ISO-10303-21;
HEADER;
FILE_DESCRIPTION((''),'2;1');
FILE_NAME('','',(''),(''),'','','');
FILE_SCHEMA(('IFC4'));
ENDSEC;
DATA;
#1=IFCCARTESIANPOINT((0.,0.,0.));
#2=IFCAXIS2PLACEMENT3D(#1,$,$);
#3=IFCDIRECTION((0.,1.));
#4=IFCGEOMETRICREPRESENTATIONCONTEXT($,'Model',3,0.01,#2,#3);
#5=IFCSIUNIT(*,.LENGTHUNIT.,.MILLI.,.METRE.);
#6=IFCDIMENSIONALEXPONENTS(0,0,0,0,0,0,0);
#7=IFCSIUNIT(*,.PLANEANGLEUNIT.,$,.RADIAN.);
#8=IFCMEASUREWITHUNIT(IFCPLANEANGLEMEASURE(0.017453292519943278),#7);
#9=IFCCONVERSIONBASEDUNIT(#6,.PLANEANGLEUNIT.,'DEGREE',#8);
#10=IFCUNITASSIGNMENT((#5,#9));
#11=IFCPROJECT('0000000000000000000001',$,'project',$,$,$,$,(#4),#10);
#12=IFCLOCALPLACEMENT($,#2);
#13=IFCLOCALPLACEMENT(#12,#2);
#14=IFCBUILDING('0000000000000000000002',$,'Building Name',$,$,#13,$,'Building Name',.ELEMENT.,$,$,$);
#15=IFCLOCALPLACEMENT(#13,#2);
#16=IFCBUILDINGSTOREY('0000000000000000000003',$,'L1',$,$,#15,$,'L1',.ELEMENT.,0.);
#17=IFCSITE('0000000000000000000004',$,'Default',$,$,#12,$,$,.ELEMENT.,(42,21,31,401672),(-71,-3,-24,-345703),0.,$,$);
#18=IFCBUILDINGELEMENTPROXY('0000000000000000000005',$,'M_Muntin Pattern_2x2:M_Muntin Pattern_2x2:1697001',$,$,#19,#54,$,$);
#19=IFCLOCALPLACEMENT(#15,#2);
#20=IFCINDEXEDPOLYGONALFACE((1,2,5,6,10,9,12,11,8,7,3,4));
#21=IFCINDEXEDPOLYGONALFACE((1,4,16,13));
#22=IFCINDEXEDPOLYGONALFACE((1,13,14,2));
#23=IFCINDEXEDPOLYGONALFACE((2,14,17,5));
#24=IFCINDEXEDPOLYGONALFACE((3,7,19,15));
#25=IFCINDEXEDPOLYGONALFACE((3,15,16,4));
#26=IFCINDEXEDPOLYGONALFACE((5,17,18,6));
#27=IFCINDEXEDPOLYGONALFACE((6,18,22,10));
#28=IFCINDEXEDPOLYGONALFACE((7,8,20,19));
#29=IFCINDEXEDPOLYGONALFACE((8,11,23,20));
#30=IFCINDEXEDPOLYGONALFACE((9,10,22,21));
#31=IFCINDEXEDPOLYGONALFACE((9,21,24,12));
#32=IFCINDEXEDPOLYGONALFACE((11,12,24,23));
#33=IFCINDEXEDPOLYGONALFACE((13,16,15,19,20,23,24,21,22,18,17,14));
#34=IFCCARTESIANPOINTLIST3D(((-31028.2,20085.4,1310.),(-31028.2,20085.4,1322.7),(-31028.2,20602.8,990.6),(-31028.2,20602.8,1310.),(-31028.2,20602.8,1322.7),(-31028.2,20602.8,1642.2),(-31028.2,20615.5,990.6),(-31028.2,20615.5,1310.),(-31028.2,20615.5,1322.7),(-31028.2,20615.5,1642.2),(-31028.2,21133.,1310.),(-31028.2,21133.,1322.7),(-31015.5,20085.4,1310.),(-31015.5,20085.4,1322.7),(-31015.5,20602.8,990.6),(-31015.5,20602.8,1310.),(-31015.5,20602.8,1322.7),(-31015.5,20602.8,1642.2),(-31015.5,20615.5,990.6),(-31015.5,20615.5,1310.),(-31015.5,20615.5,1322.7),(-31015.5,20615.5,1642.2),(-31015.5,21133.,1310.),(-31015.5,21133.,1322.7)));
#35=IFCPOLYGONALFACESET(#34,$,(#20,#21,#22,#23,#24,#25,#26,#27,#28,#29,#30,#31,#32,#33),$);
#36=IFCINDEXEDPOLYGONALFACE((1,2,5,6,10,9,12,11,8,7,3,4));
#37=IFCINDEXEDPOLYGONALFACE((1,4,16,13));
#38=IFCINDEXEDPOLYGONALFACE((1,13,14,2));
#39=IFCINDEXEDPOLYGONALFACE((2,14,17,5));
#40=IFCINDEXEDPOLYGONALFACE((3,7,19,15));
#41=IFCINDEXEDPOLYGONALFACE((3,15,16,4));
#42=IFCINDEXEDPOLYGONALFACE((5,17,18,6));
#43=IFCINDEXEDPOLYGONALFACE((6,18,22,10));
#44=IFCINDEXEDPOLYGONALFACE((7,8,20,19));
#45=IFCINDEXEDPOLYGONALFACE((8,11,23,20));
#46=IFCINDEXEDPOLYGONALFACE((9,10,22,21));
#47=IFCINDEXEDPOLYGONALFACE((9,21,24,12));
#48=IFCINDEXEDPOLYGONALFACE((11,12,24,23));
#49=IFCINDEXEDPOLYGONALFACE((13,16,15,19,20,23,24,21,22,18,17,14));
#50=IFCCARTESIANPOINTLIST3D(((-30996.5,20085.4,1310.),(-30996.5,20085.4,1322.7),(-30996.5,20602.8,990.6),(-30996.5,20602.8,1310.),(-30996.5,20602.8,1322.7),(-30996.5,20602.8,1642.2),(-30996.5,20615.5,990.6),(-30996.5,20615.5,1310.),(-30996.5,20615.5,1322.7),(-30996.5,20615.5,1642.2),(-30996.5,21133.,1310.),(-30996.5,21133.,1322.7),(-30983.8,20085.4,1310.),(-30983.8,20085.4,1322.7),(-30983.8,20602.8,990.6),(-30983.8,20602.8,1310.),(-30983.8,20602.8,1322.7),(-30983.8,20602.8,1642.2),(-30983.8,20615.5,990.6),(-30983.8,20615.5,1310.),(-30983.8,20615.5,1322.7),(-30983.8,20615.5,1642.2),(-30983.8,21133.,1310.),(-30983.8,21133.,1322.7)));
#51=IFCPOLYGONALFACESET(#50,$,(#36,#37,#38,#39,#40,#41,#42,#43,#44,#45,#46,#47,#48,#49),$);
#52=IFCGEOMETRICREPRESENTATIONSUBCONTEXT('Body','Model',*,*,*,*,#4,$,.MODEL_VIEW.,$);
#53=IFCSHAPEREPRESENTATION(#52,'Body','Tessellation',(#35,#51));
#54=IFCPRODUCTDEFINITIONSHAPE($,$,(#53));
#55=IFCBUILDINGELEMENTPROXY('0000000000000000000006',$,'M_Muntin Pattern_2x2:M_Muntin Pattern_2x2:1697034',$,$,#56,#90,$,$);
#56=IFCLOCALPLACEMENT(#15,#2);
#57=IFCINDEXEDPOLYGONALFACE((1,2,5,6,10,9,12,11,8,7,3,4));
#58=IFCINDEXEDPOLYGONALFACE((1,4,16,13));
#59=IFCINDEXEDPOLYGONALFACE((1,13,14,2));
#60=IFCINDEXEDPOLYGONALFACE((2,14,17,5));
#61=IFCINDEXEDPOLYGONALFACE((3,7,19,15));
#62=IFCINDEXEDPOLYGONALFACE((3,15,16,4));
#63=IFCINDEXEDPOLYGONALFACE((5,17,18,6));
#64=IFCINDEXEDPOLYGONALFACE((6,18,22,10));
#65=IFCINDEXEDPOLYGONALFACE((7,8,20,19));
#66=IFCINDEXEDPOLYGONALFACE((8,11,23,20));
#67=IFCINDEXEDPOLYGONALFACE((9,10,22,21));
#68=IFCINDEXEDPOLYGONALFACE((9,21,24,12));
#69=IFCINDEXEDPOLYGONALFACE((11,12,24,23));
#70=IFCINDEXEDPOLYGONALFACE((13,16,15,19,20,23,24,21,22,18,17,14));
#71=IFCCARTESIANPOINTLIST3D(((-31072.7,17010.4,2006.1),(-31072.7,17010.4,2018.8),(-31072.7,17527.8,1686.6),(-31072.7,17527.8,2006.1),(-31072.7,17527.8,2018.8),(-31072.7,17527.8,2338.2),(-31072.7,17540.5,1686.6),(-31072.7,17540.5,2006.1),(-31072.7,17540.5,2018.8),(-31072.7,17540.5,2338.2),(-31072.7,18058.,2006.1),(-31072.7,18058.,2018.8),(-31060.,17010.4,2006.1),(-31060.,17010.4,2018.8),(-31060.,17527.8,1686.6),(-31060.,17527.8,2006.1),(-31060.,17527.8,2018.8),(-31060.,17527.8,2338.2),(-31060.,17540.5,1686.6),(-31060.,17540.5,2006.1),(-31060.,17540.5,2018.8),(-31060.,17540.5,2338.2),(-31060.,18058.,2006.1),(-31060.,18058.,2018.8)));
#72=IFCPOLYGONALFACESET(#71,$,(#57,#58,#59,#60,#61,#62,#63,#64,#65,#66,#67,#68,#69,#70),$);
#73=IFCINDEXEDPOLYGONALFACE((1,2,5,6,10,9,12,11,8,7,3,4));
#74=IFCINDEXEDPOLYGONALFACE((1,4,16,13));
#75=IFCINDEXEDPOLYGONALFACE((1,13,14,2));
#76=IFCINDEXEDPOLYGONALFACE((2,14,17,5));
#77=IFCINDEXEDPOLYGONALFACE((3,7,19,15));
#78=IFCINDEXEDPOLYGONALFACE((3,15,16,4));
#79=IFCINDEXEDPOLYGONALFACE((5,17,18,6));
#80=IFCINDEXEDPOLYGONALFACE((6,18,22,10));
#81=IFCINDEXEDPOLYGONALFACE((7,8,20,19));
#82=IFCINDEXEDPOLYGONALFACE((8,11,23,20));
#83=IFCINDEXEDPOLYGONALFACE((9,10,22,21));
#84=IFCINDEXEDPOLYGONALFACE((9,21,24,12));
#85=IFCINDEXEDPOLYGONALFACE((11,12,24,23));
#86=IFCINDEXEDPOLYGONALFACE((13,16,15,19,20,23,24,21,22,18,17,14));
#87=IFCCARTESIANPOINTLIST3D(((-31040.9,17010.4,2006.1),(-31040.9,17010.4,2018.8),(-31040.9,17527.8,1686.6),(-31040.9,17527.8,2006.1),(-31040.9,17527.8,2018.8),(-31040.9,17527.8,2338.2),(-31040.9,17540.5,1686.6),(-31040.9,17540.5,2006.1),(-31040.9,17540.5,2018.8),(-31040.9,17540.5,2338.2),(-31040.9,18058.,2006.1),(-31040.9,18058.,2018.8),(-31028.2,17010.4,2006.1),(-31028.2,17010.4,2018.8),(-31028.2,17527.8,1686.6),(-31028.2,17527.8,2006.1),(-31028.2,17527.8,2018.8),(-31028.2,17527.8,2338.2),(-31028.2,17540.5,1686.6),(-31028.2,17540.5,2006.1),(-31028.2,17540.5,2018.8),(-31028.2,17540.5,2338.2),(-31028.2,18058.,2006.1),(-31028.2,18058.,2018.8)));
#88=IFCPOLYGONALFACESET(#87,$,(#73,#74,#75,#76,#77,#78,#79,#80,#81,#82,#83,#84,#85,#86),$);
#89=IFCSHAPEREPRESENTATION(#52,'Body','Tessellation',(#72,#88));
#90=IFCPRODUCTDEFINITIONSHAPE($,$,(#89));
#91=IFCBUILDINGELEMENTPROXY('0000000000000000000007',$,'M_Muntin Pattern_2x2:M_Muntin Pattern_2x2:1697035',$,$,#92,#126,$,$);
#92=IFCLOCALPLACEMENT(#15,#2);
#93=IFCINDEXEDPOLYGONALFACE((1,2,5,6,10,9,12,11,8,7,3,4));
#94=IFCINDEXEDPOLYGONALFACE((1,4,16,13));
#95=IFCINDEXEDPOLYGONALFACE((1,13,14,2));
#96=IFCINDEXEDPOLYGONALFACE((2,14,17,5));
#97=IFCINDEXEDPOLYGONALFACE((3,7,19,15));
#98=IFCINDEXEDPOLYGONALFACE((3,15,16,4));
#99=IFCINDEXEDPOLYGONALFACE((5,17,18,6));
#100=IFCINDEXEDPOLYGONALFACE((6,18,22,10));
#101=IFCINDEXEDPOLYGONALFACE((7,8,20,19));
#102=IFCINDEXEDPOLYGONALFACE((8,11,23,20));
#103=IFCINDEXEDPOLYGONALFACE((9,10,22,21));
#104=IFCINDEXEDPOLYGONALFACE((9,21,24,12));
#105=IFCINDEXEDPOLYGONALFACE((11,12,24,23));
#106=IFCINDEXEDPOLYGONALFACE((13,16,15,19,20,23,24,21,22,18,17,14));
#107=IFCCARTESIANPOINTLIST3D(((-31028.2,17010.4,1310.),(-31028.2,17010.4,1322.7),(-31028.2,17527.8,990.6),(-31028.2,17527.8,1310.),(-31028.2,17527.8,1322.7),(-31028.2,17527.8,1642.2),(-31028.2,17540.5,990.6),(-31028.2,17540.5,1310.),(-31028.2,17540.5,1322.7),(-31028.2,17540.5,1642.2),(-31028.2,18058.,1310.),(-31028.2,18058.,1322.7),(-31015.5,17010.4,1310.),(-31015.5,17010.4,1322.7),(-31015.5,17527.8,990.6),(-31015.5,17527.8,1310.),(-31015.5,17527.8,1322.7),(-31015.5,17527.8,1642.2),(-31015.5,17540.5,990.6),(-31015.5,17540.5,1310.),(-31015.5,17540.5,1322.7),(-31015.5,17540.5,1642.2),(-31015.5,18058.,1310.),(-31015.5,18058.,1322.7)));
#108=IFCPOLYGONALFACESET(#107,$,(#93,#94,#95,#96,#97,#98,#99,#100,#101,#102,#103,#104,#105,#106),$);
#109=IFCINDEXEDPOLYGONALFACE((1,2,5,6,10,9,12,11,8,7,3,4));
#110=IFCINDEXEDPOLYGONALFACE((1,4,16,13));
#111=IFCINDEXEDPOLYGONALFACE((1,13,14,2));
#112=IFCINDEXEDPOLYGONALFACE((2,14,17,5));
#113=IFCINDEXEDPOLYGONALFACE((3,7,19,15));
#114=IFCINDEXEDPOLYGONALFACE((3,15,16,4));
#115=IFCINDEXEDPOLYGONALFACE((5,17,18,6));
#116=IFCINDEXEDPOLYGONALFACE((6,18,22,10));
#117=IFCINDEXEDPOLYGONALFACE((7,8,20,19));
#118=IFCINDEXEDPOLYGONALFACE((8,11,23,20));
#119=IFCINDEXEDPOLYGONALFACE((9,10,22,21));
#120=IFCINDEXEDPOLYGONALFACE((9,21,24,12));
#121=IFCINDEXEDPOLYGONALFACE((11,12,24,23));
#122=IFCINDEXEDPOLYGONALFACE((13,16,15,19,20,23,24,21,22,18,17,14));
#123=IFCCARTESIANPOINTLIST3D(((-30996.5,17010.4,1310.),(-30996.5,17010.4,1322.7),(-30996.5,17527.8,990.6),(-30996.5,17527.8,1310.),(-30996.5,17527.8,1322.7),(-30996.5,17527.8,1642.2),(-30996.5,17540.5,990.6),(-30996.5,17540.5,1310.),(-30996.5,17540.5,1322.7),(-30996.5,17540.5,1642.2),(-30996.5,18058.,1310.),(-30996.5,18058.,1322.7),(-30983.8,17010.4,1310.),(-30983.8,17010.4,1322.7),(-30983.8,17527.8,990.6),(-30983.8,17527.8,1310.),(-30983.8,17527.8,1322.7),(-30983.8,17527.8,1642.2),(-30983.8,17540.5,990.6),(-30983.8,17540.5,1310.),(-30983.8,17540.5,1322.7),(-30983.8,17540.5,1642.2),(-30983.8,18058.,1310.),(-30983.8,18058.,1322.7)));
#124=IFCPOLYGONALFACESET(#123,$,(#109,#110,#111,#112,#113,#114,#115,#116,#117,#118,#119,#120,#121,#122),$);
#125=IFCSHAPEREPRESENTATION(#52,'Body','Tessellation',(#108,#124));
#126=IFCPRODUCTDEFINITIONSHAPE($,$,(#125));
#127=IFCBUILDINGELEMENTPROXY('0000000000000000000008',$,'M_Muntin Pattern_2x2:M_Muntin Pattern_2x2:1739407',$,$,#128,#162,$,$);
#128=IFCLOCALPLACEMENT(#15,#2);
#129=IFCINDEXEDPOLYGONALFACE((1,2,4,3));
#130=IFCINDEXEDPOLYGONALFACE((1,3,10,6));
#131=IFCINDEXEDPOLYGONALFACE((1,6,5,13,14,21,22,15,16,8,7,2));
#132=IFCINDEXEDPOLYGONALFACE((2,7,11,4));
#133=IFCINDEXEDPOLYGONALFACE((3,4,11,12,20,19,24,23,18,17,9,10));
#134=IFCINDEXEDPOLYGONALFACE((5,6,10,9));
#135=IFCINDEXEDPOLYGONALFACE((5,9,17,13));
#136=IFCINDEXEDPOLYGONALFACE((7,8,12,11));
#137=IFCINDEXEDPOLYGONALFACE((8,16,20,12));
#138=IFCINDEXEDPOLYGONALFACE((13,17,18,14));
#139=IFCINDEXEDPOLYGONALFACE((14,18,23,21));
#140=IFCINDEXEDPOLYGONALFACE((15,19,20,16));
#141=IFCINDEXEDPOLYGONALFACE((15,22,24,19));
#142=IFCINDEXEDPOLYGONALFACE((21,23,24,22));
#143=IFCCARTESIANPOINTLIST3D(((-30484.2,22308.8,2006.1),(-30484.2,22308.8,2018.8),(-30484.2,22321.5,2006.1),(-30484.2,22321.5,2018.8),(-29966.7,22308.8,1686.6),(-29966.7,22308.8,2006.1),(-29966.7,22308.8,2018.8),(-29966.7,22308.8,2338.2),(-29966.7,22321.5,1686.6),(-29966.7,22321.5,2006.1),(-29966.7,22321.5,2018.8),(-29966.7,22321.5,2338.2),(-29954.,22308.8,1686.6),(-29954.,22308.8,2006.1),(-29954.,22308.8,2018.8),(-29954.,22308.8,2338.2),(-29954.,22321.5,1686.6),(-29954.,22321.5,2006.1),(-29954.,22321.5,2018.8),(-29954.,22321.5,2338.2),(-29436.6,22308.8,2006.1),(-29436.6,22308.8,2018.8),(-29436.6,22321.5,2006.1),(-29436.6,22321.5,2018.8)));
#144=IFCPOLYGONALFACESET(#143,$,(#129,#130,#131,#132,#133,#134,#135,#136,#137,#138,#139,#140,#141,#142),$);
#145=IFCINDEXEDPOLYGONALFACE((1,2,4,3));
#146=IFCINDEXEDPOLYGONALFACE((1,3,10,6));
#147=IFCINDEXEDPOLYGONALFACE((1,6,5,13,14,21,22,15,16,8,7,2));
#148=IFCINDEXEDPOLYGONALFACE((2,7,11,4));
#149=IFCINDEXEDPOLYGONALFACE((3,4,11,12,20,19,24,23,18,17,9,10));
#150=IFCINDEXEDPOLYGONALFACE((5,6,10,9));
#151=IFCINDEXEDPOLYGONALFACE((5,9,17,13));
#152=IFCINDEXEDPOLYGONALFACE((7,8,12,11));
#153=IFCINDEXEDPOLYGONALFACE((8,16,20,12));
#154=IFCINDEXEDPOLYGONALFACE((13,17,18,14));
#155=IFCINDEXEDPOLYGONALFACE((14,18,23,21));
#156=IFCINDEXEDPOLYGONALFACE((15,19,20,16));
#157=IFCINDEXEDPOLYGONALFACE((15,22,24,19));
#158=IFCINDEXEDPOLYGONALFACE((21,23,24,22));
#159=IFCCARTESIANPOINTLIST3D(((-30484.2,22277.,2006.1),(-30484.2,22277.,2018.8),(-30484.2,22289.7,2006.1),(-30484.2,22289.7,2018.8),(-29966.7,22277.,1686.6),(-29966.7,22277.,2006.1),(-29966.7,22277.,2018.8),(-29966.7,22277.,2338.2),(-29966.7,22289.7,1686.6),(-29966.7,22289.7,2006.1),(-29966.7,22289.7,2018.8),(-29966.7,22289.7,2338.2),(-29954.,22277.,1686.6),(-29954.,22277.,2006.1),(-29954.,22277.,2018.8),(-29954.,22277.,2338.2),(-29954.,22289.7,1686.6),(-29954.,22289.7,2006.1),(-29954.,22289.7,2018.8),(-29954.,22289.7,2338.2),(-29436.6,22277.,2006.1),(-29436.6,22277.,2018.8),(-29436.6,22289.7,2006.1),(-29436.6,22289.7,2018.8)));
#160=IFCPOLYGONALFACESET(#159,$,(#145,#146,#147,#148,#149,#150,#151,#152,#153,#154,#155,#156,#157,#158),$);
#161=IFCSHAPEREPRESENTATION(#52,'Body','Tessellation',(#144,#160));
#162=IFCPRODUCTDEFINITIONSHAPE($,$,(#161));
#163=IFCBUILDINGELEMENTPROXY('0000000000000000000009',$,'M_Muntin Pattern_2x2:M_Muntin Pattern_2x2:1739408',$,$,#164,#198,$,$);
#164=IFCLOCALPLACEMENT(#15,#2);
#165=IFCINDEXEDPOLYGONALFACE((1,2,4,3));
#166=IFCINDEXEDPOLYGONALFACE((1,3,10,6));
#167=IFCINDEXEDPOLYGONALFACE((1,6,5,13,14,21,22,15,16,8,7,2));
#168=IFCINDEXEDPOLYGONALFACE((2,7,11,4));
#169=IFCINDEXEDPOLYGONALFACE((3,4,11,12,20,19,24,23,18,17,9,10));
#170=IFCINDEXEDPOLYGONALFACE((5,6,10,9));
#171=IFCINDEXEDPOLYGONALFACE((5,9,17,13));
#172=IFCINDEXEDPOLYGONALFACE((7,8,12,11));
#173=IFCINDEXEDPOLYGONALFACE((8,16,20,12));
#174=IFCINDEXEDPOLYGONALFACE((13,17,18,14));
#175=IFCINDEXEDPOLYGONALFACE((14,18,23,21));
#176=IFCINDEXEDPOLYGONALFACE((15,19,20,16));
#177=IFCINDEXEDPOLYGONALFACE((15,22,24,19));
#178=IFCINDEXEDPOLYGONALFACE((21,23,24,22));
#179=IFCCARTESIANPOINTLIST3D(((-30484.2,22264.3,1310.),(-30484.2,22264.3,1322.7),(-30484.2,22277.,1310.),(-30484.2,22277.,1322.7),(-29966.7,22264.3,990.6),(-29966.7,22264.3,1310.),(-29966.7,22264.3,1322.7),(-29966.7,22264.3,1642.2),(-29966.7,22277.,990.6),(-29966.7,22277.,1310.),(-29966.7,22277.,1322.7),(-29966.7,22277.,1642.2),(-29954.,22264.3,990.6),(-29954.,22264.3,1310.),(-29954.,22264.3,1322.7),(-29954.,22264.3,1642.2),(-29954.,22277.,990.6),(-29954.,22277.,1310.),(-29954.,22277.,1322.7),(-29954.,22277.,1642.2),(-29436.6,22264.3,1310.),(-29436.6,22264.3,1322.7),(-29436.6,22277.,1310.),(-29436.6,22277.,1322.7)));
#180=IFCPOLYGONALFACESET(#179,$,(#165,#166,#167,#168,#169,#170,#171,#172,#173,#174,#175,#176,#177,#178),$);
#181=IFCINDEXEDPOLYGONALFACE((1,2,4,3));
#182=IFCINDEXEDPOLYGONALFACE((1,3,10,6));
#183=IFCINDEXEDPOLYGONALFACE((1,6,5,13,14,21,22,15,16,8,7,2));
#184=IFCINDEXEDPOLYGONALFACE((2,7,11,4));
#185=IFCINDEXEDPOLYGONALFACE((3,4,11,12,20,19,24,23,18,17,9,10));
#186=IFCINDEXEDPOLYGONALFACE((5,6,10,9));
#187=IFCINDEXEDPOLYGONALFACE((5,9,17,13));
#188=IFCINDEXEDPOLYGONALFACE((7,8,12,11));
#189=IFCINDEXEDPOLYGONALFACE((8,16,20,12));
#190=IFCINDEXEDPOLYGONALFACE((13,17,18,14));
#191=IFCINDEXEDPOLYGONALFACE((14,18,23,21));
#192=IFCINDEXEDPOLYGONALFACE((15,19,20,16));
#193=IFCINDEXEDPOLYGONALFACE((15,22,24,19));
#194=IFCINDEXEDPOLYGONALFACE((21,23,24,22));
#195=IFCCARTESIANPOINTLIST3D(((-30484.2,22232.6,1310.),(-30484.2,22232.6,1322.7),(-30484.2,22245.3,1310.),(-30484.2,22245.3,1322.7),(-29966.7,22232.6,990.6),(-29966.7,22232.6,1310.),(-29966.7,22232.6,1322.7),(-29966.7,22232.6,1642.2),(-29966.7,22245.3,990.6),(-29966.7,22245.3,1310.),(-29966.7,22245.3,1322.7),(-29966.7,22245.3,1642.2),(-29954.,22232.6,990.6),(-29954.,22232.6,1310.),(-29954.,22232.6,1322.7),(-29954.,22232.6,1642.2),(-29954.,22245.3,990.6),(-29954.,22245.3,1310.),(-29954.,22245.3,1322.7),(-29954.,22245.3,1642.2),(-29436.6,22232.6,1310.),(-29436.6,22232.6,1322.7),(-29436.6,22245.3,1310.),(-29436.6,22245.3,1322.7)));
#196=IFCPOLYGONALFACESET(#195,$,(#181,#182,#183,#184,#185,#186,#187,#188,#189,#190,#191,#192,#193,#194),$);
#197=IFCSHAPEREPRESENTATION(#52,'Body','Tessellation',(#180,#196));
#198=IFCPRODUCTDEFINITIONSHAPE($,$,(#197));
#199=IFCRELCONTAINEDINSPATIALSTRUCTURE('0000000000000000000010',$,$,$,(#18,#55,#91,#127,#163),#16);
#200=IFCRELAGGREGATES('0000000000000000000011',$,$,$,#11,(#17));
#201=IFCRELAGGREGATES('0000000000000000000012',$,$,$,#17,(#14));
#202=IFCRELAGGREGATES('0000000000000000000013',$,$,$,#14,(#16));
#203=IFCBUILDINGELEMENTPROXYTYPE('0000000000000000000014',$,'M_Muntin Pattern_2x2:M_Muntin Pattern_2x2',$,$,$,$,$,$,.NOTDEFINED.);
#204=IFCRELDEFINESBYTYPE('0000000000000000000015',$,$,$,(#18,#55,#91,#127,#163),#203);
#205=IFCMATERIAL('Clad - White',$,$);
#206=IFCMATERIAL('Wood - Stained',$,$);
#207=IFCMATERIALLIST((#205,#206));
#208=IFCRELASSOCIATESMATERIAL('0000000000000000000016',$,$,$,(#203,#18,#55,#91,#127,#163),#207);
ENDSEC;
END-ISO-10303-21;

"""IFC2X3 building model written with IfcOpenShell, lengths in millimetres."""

from ifc_helpers import new_model, entity, si_unit, converted_unit, direction, frame, origin, place, context, subcontext, project, spatial, polyline, outline, extrude, source, transform, mapped, material, material_list, type_object, type_shapes, element, save


model = new_model("IFC2X3")

# Units and contexts
model_context = context("Model", 3, precision=0.01, world=origin(), true_north=direction((0.0, 1.0)))
body_context = subcontext(model_context, "Body", "Model", "MODEL_VIEW")
ifc_project = project(units=[si_unit("LENGTHUNIT", "METRE", prefix="MILLI"), converted_unit("PLANEANGLEUNIT", "DEGREE", entity("IfcPlaneAngleMeasure", 0.017453292519943278), si_unit("PLANEANGLEUNIT", "RADIAN"), dimensions=[0, 0, 0, 0, 0, 0, 0])], contexts=[model_context])

# Site, building, storey
site_placement = place(None, origin())
site = spatial("IfcSite", under=ifc_project, at=site_placement, Name="Default", CompositionType="ELEMENT", RefLatitude=(42, 21, 31, 401672), RefLongitude=(-71, -3, -24, -345703), RefElevation=0.0)
building_placement = place(site_placement, origin())
building = spatial("IfcBuilding", under=site, at=building_placement, Name="Building Name", LongName="Building Name", CompositionType="ELEMENT")
storey_placement = place(building_placement, origin())
storey = spatial("IfcBuildingStorey", under=building, at=storey_placement, Name="L1", LongName="L1", CompositionType="ELEMENT", Elevation=0.0)

# Shared definitions
ifc_material_1 = material(Name="Wood - Stained")

# Building element proxies
ifc_material_2 = material(Name="Clad - White")
ifc_material_list_1 = material_list([ifc_material_2, ifc_material_1])
building_element_proxy_type_1 = type_object("IfcBuildingElementProxyType", Name="M_Muntin Pattern_2x2:M_Muntin Pattern_2x2", PredefinedType="NOTDEFINED", material=ifc_material_list_1)
shared_shape_1 = source(origin(), body_context, "Body", "SweptSolid", [
    extrude(outline(polyline([(6.4, -6.4), (325.8, -6.4), (325.8, 6.3), (6.4, 6.3), (6.4, 523.8), (-6.3, 523.8), (-6.3, 6.3), (-325.8, 6.3), (-325.8, -6.4), (-6.3, -6.4), (-6.3, -523.8), (6.4, -523.8), (6.4, -6.4)])), frame((0.0, 9.5, 325.8), z_axis=(0.0, 1.0, 0.0), x_axis=(0.0, 0.0, 1.0)), (0.0, 0.0, 1.0), 12.7),
    extrude(outline(polyline([(6.4, -6.4), (325.8, -6.4), (325.8, 6.3), (6.4, 6.3), (6.4, 523.8), (-6.3, 523.8), (-6.3, 6.3), (-325.8, 6.3), (-325.8, -6.4), (-6.3, -6.4), (-6.3, -523.8), (6.4, -523.8), (6.4, -6.4)])), frame((0.0, -22.2, 325.8), z_axis=(0.0, 1.0, 0.0), x_axis=(0.0, 0.0, 1.0)), (0.0, 0.0, 1.0), 12.7),
])
type_shapes(building_element_proxy_type_1, [shared_shape_1])
for number, where, z_axis, x_axis, name in (
    (1, (-31006.0, 20609.2, 990.6), (0.0, 0.0, 1.0), (0.0, 1.0, 0.0), "M_Muntin Pattern_2x2:M_Muntin Pattern_2x2:1697001"),
    (2, (-31050.4, 17534.2, 1686.6), (0.0, 0.0, 1.0), (0.0, 1.0, 0.0), "M_Muntin Pattern_2x2:M_Muntin Pattern_2x2:1697034"),
    (3, (-31006.0, 17534.2, 990.6), (0.0, 0.0, 1.0), (0.0, 1.0, 0.0), "M_Muntin Pattern_2x2:M_Muntin Pattern_2x2:1697035"),
):
    element("IfcBuildingElementProxy", number, at=place(storey_placement, frame(where, z_axis=z_axis, x_axis=x_axis)), inside=storey, type_object=building_element_proxy_type_1, material=ifc_material_list_1, Name=name, context=body_context, shape_type="MappedRepresentation", body=[
        mapped(shared_shape_1, transform((0.0, 0.0, 0.0), scale=1.0)),
    ])
for number, where, name in (
    (4, (-29960.4, 22299.3, 1686.6), "M_Muntin Pattern_2x2:M_Muntin Pattern_2x2:1739407"),
    (5, (-29960.4, 22254.8, 990.6), "M_Muntin Pattern_2x2:M_Muntin Pattern_2x2:1739408"),
):
    element("IfcBuildingElementProxy", number, at=place(storey_placement, frame(where)), inside=storey, type_object=building_element_proxy_type_1, material=ifc_material_list_1, Name=name, context=body_context, shape_type="MappedRepresentation", body=[
        mapped(shared_shape_1, transform((0.0, 0.0, 0.0), scale=1.0)),
    ])

save(model, "model.ifc")
